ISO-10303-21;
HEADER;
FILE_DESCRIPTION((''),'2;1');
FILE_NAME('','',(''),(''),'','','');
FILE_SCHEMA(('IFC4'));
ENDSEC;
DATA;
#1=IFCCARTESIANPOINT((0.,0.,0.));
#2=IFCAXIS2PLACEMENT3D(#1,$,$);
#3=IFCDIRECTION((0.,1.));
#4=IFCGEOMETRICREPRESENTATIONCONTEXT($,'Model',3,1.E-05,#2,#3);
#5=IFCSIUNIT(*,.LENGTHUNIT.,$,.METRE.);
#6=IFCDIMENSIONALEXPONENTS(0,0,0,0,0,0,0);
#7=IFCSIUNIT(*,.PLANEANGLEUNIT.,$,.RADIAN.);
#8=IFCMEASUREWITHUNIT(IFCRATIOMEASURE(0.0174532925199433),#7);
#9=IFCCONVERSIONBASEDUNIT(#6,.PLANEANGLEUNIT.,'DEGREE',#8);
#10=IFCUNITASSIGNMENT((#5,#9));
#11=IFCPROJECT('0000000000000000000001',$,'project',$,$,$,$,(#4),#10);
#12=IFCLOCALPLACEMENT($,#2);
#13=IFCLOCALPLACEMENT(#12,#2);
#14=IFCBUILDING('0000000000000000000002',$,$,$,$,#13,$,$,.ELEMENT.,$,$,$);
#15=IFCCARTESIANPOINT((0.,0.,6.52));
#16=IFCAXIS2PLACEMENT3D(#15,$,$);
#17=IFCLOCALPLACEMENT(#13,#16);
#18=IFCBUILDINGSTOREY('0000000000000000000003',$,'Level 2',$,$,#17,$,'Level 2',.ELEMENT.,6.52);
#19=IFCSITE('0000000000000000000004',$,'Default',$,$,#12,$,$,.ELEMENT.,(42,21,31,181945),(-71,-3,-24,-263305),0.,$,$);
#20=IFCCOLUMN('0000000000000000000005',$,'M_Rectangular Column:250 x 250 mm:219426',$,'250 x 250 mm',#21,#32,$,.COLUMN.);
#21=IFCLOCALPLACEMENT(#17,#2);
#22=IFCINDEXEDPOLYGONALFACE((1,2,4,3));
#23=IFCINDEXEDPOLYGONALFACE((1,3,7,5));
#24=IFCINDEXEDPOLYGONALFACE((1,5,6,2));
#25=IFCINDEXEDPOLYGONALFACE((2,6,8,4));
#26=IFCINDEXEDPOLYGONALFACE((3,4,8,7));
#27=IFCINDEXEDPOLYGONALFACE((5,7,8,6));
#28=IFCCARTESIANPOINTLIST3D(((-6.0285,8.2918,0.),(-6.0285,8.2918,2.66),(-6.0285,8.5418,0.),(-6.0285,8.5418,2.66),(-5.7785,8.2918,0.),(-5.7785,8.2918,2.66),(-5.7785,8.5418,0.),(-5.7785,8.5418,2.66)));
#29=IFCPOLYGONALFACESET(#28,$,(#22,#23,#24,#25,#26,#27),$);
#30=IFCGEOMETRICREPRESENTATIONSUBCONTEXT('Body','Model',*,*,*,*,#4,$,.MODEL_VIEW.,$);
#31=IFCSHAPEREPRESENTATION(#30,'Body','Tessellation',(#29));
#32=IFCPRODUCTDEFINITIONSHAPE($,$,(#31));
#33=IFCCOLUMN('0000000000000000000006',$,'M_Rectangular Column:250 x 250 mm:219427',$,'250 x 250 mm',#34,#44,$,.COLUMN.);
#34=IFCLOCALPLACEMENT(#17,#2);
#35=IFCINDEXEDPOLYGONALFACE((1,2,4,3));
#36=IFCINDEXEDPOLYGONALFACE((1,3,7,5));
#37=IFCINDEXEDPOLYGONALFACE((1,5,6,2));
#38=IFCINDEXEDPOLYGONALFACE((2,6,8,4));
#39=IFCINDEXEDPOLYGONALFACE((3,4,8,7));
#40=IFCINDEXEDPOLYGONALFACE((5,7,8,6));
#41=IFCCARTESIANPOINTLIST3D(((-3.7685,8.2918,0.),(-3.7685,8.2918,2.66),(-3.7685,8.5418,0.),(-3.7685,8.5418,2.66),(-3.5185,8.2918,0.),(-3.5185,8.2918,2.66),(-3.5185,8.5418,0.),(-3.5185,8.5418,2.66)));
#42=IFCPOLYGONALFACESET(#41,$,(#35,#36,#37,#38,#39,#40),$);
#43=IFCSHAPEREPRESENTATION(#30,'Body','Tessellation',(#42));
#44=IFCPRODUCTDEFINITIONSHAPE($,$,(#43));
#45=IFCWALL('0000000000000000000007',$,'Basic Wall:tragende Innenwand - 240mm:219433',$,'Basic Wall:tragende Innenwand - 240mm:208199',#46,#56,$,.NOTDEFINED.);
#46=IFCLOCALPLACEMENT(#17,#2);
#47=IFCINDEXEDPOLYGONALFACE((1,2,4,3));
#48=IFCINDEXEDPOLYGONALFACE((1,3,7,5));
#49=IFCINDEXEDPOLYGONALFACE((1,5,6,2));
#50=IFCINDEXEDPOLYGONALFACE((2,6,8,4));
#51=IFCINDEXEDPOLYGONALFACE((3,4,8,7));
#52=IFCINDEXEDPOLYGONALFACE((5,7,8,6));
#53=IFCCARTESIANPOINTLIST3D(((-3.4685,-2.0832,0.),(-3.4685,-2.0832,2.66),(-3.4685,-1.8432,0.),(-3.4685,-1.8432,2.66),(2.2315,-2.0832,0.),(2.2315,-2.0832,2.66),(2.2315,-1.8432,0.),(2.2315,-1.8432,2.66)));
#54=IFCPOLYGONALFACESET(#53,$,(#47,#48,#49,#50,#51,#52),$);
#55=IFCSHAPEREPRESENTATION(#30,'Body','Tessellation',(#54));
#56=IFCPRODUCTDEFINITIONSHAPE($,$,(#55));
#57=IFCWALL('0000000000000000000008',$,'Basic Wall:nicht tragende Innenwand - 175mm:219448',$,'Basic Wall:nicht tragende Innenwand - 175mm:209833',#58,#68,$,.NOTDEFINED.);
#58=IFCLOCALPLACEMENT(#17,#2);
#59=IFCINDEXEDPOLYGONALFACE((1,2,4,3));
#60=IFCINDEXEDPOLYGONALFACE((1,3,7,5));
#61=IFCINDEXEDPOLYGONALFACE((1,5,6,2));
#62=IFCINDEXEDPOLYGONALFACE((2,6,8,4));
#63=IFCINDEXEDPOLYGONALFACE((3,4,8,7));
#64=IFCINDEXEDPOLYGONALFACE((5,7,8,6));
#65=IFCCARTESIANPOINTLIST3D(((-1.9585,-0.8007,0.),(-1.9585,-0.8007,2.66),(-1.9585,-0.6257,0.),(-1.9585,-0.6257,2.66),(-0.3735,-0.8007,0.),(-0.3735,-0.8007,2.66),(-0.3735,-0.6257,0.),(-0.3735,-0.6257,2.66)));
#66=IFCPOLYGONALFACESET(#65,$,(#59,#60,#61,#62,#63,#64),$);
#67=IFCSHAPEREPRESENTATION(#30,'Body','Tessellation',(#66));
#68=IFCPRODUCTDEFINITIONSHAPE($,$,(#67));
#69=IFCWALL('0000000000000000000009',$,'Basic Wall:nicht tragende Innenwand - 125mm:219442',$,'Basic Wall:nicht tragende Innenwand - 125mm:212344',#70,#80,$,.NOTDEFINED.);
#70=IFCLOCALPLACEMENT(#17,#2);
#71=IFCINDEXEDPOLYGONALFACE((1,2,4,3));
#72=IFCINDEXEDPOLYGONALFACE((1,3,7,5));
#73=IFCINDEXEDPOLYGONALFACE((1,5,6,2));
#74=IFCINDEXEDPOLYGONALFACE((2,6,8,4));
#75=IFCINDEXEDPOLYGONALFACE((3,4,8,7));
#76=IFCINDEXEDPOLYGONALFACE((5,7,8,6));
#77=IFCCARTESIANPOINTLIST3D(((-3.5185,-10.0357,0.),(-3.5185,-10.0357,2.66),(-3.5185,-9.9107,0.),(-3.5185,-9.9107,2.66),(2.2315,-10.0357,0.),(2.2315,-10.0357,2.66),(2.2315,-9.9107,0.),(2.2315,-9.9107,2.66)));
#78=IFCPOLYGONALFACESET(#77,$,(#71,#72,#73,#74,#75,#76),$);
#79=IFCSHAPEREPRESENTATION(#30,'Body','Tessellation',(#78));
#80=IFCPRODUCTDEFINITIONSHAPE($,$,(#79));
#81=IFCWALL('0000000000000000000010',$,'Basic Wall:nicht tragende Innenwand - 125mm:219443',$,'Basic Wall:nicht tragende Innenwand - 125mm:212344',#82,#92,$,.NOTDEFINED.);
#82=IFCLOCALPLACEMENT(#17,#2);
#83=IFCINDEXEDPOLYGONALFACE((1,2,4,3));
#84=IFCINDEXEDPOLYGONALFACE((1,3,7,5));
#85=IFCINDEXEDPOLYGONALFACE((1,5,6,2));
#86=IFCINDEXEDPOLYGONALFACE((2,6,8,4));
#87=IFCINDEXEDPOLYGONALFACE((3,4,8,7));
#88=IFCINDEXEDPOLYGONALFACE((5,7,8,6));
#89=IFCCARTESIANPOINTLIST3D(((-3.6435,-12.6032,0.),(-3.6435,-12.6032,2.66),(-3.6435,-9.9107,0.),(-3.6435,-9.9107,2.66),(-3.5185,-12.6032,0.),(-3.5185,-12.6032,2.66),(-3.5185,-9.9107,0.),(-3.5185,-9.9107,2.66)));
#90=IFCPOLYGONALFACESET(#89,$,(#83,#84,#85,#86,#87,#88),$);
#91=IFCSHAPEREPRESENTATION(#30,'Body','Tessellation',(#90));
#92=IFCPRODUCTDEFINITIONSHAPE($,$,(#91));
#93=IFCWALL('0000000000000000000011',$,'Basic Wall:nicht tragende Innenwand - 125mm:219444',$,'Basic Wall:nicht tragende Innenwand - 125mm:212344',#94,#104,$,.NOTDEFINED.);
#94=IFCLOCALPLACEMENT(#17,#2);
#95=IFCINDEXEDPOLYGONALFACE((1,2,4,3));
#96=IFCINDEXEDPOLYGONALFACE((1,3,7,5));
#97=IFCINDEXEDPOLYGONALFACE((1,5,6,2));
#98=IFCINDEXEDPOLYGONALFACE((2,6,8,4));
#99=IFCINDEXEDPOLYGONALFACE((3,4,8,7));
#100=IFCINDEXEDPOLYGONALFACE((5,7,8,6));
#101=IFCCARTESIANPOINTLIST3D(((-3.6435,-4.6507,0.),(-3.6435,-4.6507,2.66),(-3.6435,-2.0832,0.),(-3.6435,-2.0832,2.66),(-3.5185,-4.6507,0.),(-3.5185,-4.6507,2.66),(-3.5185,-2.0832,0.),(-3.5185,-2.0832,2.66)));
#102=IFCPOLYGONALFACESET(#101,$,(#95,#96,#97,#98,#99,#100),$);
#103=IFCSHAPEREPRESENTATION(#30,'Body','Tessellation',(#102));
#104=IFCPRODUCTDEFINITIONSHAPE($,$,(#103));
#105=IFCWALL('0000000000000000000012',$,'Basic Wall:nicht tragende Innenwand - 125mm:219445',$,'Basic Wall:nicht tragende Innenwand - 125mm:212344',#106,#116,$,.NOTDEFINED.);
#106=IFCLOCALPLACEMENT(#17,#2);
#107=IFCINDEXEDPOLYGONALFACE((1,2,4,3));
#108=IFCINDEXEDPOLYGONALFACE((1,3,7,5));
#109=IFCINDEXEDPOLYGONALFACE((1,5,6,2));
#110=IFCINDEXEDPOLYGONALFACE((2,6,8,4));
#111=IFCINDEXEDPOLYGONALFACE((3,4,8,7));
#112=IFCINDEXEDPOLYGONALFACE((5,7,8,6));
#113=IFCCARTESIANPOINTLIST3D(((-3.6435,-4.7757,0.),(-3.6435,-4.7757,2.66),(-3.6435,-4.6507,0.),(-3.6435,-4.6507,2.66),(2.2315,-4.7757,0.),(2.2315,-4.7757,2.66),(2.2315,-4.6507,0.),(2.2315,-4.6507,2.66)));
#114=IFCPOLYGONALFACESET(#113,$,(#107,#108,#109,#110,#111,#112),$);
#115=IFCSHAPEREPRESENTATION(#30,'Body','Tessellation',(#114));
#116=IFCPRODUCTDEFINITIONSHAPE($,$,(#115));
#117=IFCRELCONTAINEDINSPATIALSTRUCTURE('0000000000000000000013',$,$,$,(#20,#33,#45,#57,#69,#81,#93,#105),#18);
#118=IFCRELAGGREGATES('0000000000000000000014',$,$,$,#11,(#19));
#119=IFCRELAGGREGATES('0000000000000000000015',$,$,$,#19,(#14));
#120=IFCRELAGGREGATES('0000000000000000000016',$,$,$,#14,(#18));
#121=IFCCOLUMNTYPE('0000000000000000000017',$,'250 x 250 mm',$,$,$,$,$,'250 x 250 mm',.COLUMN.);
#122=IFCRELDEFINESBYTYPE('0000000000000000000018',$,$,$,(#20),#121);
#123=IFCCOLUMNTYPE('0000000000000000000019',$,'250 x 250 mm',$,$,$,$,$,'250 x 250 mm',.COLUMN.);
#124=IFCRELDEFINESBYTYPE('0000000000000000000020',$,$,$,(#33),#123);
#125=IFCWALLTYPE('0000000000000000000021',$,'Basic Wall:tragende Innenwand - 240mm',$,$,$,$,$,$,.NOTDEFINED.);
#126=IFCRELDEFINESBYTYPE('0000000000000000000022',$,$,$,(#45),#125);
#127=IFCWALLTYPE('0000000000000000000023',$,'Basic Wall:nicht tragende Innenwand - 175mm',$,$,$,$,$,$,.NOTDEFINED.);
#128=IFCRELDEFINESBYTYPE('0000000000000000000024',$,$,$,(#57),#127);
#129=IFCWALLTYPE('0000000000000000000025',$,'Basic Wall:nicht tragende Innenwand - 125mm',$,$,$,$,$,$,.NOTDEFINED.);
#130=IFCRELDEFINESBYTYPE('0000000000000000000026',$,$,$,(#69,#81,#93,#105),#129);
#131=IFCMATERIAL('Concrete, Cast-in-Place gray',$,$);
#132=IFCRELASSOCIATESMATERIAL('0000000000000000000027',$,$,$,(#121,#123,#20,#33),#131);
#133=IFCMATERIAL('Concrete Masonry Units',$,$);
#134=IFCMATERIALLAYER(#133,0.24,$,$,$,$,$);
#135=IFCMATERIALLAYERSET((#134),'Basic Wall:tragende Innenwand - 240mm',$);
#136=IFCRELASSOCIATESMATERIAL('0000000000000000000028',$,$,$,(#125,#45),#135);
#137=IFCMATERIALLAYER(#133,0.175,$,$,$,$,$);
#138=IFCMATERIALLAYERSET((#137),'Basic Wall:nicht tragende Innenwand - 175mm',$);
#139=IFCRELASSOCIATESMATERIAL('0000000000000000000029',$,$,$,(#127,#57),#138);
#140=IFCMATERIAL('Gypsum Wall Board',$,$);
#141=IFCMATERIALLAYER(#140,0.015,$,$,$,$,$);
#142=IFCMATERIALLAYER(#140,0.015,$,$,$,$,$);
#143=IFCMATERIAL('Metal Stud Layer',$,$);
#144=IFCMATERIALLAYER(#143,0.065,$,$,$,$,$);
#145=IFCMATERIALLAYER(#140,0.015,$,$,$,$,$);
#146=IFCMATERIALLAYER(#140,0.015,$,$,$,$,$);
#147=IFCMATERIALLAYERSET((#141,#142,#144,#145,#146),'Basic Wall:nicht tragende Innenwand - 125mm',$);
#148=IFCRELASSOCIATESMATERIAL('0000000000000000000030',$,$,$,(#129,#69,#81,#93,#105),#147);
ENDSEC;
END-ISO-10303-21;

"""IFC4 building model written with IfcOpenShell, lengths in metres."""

from ifc_helpers import new_model, entity, si_unit, converted_unit, direction, frame, frame_2d, origin, place, context, subcontext, project, spatial, rectangle, extrude, source, transform, mapped, material, layer, layer_set, layer_usage, material_profile, profile_set, profile_usage, type_object, type_shapes, element, save


model = new_model("IFC4")

# Units and contexts
model_context = context("Model", 3, precision=1e-05, world=origin(), true_north=direction((0.0, 1.0)))
body_context = subcontext(model_context, "Body", "Model", "MODEL_VIEW")
ifc_project = project(units=[si_unit("LENGTHUNIT", "METRE"), converted_unit("PLANEANGLEUNIT", "DEGREE", entity("IfcRatioMeasure", 0.0174532925199433), si_unit("PLANEANGLEUNIT", "RADIAN"), dimensions=[0, 0, 0, 0, 0, 0, 0])], contexts=[model_context])

# Site, building, storey
site_placement = place(None, origin())
site = spatial("IfcSite", under=ifc_project, at=site_placement, Name="Default", CompositionType="ELEMENT", RefLatitude=(42, 21, 31, 181945), RefLongitude=(-71, -3, -24, -263305), RefElevation=0.0)
building_placement = place(site_placement, origin())
building = spatial("IfcBuilding", under=site, at=building_placement, CompositionType="ELEMENT")
storey_placement = place(building_placement, frame((0.0, 0.0, 6.52)))
storey = spatial("IfcBuildingStorey", under=building, at=storey_placement, Name="Level 2", LongName="Level 2", CompositionType="ELEMENT", Elevation=6.52)

# Columns
ifc_material_1 = material(Name="Concrete, Cast-in-Place gray")
ifc_material_profile = material_profile(ifc_material_1, rectangle(XDim=0.25, YDim=0.25, at=frame_2d((0.0, 0.0), x_axis=(1.0, 0.0))))
ifc_profile_set = profile_set([ifc_material_profile], Name="250 x 250 mm")
ifc_profile_usage_1 = profile_usage(ifc_profile_set)
column_type_1 = type_object("IfcColumnType", Name="250 x 250 mm", ElementType="250 x 250 mm", PredefinedType="COLUMN", material=ifc_profile_set)
shared_shape_1 = source(origin(), body_context, "Body", "SweptSolid", [
    extrude(rectangle(XDim=0.25, YDim=0.25, at=frame_2d((0.0, 0.0), x_axis=(1.0, 0.0))), frame((-5.9035, 8.4168, 6.52), z_axis=(0.0, 0.0, 1.0), x_axis=(0.0, -1.0, 0.0)), (0.0, 0.0, 1.0), 2.66),
])
type_shapes(column_type_1, [shared_shape_1])
column_1_placement = place(storey_placement, frame((0.0, 0.0, -6.52)))
element("IfcColumn", 1, at=column_1_placement, inside=storey, type_object=column_type_1, material=ifc_profile_usage_1, Name="M_Rectangular Column:250 x 250 mm:219426", ObjectType="250 x 250 mm", PredefinedType="COLUMN", context=body_context, shape_type="MappedRepresentation", body=[
    mapped(shared_shape_1, transform((0.0, 0.0, 0.0), scale=1.0)),
])
ifc_profile_usage_2 = profile_usage(ifc_profile_set)
column_type_2 = type_object("IfcColumnType", Name="250 x 250 mm", ElementType="250 x 250 mm", PredefinedType="COLUMN", material=ifc_profile_set)
shared_shape_2 = source(origin(), body_context, "Body", "SweptSolid", [
    extrude(rectangle(XDim=0.25, YDim=0.25, at=frame_2d((0.0, 0.0), x_axis=(1.0, 0.0))), frame((-3.6435, 8.4168, 6.52), z_axis=(0.0, 0.0, 1.0), x_axis=(0.0, -1.0, 0.0)), (0.0, 0.0, 1.0), 2.66),
])
type_shapes(column_type_2, [shared_shape_2])
column_2_placement = place(storey_placement, frame((0.0, 0.0, -6.52)))
element("IfcColumn", 2, at=column_2_placement, inside=storey, type_object=column_type_2, material=ifc_profile_usage_2, Name="M_Rectangular Column:250 x 250 mm:219427", ObjectType="250 x 250 mm", PredefinedType="COLUMN", context=body_context, shape_type="MappedRepresentation", body=[
    mapped(shared_shape_2, transform((0.0, 0.0, 0.0), scale=1.0)),
])

# Walls
ifc_material_2 = material(Name="Concrete Masonry Units")
ifc_layer_1 = layer(ifc_material_2, 0.24)
ifc_layer_set_1 = layer_set([ifc_layer_1], Name="Basic Wall:tragende Innenwand - 240mm")
ifc_layer_usage_1 = layer_usage(ifc_layer_set_1, "AXIS2", "NEGATIVE", 0.12)
wall_type_1 = type_object("IfcWallType", Name="Basic Wall:tragende Innenwand - 240mm", PredefinedType="NOTDEFINED", material=ifc_layer_set_1)
wall_1_placement = place(storey_placement, frame((-3.4685, -1.9632, 0.0)))
element("IfcWall", 3, at=wall_1_placement, inside=storey, type_object=wall_type_1, material=ifc_layer_usage_1, Name="Basic Wall:tragende Innenwand - 240mm:219433", ObjectType="Basic Wall:tragende Innenwand - 240mm:208199", PredefinedType="NOTDEFINED", context=body_context, shape_type="SweptSolid", body=[
    extrude(rectangle(XDim=5.7, YDim=0.24, at=frame_2d((2.85, 0.0), x_axis=(-1.0, 0.0))), origin(), (0.0, 0.0, 1.0), 2.66),
])
ifc_layer_2 = layer(ifc_material_2, 0.175)
ifc_layer_set_2 = layer_set([ifc_layer_2], Name="Basic Wall:nicht tragende Innenwand - 175mm")
ifc_layer_usage_2 = layer_usage(ifc_layer_set_2, "AXIS2", "NEGATIVE", 0.0875)
wall_type_2 = type_object("IfcWallType", Name="Basic Wall:nicht tragende Innenwand - 175mm", PredefinedType="NOTDEFINED", material=ifc_layer_set_2)
wall_2_placement = place(storey_placement, frame((-1.9585, -0.7132, 0.0)))
element("IfcWall", 4, at=wall_2_placement, inside=storey, type_object=wall_type_2, material=ifc_layer_usage_2, Name="Basic Wall:nicht tragende Innenwand - 175mm:219448", ObjectType="Basic Wall:nicht tragende Innenwand - 175mm:209833", PredefinedType="NOTDEFINED", context=body_context, shape_type="SweptSolid", body=[
    extrude(rectangle(XDim=1.585, YDim=0.175, at=frame_2d((0.7925, 0.0), x_axis=(-1.0, 0.0))), origin(), (0.0, 0.0, 1.0), 2.66),
])
ifc_material_3 = material(Name="Gypsum Wall Board")
ifc_layer_3 = layer(ifc_material_3, 0.015)
ifc_layer_4 = layer(ifc_material_3, 0.015)
ifc_material_4 = material(Name="Metal Stud Layer")
ifc_layer_5 = layer(ifc_material_4, 0.065)
ifc_layer_6 = layer(ifc_material_3, 0.015)
ifc_layer_7 = layer(ifc_material_3, 0.015)
ifc_layer_set_3 = layer_set([ifc_layer_3, ifc_layer_4, ifc_layer_5, ifc_layer_6, ifc_layer_7], Name="Basic Wall:nicht tragende Innenwand - 125mm")
ifc_layer_usage_3 = layer_usage(ifc_layer_set_3, "AXIS2", "NEGATIVE", 0.0625)
wall_type_3 = type_object("IfcWallType", Name="Basic Wall:nicht tragende Innenwand - 125mm", PredefinedType="NOTDEFINED", material=ifc_layer_set_3)
wall_3_placement = place(storey_placement, frame((-3.5185, -9.9732, 0.0)))
element("IfcWall", 5, at=wall_3_placement, inside=storey, type_object=wall_type_3, material=ifc_layer_usage_3, Name="Basic Wall:nicht tragende Innenwand - 125mm:219442", ObjectType="Basic Wall:nicht tragende Innenwand - 125mm:212344", PredefinedType="NOTDEFINED", context=body_context, shape_type="SweptSolid", body=[
    extrude(rectangle(XDim=5.75, YDim=0.125, at=frame_2d((2.875, 0.0), x_axis=(-1.0, 0.0))), origin(), (0.0, 0.0, 1.0), 2.66),
])
ifc_layer_usage_4 = layer_usage(ifc_layer_set_3, "AXIS2", "NEGATIVE", 0.0625)
wall_4_placement = place(storey_placement, frame((-3.581, -9.9107, 0.0), z_axis=(0.0, 0.0, 1.0), x_axis=(0.0, -1.0, 0.0)))
element("IfcWall", 6, at=wall_4_placement, inside=storey, type_object=wall_type_3, material=ifc_layer_usage_4, Name="Basic Wall:nicht tragende Innenwand - 125mm:219443", ObjectType="Basic Wall:nicht tragende Innenwand - 125mm:212344", PredefinedType="NOTDEFINED", context=body_context, shape_type="SweptSolid", body=[
    extrude(rectangle(XDim=2.6925, YDim=0.125, at=frame_2d((1.3463, 0.0), x_axis=(-1.0, 0.0))), origin(), (0.0, 0.0, 1.0), 2.66),
])
ifc_layer_usage_5 = layer_usage(ifc_layer_set_3, "AXIS2", "NEGATIVE", 0.0625)
wall_5_placement = place(storey_placement, frame((-3.581, -2.0832, 0.0), z_axis=(0.0, 0.0, 1.0), x_axis=(0.0, -1.0, 0.0)))
element("IfcWall", 7, at=wall_5_placement, inside=storey, type_object=wall_type_3, material=ifc_layer_usage_5, Name="Basic Wall:nicht tragende Innenwand - 125mm:219444", ObjectType="Basic Wall:nicht tragende Innenwand - 125mm:212344", PredefinedType="NOTDEFINED", context=body_context, shape_type="SweptSolid", body=[
    extrude(rectangle(XDim=2.5675, YDim=0.125, at=frame_2d((1.2838, 0.0), x_axis=(-1.0, 0.0))), origin(), (0.0, 0.0, 1.0), 2.66),
])
ifc_layer_usage_6 = layer_usage(ifc_layer_set_3, "AXIS2", "POSITIVE", -0.0625)
wall_6_placement = place(storey_placement, frame((-3.6435, -4.7132, 0.0)))
element("IfcWall", 8, at=wall_6_placement, inside=storey, type_object=wall_type_3, material=ifc_layer_usage_6, Name="Basic Wall:nicht tragende Innenwand - 125mm:219445", ObjectType="Basic Wall:nicht tragende Innenwand - 125mm:212344", PredefinedType="NOTDEFINED", context=body_context, shape_type="SweptSolid", body=[
    extrude(rectangle(XDim=5.875, YDim=0.125, at=frame_2d((2.9375, 0.0), x_axis=(-1.0, 0.0))), origin(), (0.0, 0.0, 1.0), 2.66),
])

save(model, "model.ifc")
